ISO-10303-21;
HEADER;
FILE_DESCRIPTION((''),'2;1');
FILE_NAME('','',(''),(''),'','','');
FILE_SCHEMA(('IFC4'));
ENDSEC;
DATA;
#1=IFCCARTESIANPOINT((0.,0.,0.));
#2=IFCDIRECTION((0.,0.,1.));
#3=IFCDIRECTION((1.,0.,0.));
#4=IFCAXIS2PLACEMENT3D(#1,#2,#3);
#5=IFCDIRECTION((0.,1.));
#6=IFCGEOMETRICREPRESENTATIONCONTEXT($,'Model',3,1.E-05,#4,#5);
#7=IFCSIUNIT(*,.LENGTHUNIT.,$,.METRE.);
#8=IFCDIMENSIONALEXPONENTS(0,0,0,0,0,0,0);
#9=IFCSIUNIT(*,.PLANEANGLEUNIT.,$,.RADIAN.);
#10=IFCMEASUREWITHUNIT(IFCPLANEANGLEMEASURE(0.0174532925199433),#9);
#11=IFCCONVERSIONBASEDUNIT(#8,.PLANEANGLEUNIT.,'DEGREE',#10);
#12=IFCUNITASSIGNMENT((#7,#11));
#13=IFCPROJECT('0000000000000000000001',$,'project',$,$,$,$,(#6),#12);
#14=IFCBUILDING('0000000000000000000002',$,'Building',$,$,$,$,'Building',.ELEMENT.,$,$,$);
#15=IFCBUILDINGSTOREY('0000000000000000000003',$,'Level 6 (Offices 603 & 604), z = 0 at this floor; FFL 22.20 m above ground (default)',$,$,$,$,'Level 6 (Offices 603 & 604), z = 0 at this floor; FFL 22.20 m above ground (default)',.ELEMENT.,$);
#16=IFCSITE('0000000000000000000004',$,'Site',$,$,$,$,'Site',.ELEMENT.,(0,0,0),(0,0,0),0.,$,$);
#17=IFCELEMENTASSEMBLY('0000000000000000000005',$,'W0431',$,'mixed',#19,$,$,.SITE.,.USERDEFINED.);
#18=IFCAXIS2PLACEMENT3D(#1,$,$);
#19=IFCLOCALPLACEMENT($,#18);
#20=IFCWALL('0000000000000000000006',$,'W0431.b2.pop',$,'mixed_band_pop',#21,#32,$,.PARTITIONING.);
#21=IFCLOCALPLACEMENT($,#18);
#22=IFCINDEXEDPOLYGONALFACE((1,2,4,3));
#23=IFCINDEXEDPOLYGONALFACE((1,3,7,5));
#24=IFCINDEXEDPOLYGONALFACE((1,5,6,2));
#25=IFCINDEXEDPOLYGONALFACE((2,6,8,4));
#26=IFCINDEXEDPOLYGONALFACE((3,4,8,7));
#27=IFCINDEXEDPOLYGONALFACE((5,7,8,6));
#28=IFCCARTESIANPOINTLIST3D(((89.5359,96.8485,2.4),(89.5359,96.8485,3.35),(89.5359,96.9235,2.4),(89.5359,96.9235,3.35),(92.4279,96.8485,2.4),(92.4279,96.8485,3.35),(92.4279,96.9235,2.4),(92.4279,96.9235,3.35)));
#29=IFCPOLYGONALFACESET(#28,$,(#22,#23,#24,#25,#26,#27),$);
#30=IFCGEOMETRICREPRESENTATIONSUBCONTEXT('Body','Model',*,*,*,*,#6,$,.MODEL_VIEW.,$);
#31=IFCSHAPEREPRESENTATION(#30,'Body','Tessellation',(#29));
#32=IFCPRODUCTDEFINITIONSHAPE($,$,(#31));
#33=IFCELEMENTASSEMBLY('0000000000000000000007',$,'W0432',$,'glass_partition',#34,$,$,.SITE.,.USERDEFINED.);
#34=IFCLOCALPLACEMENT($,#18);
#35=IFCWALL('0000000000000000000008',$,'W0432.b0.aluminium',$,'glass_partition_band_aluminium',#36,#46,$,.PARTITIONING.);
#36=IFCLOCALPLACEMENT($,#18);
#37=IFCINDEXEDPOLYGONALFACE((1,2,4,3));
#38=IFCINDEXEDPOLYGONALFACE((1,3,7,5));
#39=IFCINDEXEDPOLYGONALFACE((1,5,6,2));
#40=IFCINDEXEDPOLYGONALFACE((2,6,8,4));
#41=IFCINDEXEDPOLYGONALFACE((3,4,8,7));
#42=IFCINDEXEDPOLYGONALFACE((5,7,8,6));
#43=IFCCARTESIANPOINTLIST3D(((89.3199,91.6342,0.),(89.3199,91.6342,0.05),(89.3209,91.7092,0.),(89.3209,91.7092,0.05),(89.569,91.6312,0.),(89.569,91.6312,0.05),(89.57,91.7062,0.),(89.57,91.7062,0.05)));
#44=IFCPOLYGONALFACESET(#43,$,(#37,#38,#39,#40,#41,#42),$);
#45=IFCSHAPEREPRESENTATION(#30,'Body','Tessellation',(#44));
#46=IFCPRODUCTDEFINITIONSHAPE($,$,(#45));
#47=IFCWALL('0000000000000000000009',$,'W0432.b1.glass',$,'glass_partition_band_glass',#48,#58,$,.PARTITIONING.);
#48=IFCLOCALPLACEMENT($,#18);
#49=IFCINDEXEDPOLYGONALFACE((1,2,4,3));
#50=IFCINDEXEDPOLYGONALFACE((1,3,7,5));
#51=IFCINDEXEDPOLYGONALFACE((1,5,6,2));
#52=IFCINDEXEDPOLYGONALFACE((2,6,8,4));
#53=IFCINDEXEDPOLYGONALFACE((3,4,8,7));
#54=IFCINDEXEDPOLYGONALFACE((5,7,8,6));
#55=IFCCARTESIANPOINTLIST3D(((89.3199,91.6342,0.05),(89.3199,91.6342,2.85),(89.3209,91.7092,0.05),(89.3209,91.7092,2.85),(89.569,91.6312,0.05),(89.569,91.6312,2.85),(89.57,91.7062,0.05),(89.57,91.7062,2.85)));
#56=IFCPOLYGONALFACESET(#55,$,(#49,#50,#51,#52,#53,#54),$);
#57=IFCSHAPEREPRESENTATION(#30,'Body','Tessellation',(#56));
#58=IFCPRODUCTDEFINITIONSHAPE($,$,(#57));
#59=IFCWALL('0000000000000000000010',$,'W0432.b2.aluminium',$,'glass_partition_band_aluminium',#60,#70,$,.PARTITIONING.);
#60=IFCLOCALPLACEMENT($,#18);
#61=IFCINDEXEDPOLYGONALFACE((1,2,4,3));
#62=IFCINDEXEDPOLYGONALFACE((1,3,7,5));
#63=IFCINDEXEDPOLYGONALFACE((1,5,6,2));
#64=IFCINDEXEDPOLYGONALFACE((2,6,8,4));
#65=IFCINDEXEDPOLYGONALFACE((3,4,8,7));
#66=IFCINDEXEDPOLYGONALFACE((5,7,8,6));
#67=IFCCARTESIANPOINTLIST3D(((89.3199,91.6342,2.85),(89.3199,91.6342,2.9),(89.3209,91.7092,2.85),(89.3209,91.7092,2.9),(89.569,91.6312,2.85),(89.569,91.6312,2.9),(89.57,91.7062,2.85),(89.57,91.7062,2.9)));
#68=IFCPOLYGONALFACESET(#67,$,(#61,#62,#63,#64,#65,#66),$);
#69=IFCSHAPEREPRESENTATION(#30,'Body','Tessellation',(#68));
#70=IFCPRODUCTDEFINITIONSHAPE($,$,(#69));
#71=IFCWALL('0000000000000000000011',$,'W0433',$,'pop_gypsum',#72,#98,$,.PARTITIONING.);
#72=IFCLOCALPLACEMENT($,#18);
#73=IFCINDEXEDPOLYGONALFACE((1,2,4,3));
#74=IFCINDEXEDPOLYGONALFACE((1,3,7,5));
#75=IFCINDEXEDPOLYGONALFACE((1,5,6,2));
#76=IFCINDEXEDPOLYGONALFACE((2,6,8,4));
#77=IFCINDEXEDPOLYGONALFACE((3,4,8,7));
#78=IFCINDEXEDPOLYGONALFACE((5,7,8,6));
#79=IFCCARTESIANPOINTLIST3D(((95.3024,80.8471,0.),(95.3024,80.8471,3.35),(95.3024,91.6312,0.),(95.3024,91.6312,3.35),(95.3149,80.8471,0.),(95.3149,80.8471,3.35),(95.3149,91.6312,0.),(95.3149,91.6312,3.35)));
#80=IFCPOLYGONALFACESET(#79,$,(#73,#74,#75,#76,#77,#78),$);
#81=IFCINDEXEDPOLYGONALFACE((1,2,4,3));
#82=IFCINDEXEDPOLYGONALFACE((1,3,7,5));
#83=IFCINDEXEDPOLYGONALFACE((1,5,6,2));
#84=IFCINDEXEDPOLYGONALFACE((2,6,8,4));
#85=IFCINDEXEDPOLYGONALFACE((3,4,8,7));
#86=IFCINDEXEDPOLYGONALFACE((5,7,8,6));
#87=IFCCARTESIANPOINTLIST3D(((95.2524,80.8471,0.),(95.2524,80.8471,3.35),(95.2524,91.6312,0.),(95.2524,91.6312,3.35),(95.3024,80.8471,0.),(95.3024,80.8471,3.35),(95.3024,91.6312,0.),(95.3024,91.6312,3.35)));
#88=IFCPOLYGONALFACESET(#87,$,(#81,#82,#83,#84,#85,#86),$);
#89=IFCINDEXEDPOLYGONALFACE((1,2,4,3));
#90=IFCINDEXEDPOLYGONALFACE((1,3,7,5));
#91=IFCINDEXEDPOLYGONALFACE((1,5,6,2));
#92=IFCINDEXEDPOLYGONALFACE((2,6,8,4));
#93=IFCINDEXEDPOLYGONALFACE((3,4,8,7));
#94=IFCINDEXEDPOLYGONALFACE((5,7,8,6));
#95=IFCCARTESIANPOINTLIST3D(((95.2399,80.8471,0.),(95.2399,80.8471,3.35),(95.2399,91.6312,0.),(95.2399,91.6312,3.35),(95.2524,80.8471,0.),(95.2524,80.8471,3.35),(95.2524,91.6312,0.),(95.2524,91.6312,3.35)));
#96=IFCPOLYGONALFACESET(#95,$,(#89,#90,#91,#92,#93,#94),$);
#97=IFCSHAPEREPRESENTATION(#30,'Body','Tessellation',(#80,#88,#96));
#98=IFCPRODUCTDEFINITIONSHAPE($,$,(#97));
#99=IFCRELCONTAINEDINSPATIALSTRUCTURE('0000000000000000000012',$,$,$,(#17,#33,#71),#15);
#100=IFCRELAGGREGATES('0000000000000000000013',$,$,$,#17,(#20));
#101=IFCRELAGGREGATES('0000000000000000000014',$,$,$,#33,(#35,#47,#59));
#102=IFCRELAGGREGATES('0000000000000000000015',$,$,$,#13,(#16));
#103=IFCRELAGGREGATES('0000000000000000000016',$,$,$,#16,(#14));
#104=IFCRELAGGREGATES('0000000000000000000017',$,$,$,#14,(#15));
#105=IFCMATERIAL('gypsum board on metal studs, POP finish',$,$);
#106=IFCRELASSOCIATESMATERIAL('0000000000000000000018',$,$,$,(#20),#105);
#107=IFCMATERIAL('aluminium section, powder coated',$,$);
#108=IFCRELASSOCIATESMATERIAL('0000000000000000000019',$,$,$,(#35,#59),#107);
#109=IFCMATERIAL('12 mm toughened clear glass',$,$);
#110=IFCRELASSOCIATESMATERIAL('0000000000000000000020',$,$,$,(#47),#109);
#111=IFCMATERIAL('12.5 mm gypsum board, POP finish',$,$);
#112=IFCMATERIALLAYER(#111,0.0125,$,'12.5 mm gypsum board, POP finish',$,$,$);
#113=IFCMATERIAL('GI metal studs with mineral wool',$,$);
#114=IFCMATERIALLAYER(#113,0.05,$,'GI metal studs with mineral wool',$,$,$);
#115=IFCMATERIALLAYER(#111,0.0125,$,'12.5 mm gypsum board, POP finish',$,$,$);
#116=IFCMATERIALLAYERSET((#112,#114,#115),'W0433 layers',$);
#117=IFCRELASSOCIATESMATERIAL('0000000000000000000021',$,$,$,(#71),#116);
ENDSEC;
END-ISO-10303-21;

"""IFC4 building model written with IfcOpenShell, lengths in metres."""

from ifc_helpers import new_model, entity, si_unit, converted_unit, direction, frame, frame_2d, origin_with_axes, place, context, subcontext, project, spatial, rectangle, extrude, material, layer, layer_set, layer_usage, element, aggregate, save


model = new_model("IFC4")

# Units and contexts
model_context = context("Model", 3, precision=1e-05, world=origin_with_axes(), true_north=direction((0.0, 1.0)))
body_context = subcontext(model_context, "Body", "Model", "MODEL_VIEW")
ifc_project = project(units=[si_unit("LENGTHUNIT", "METRE"), converted_unit("PLANEANGLEUNIT", "DEGREE", entity("IfcPlaneAngleMeasure", 0.0174532925199433), si_unit("PLANEANGLEUNIT", "RADIAN"), dimensions=[0, 0, 0, 0, 0, 0, 0])], contexts=[model_context])

# Site, building, storey
site = spatial("IfcSite", under=ifc_project, Name="Site", LongName="Site", CompositionType="ELEMENT", RefLatitude=(0, 0, 0), RefLongitude=(0, 0, 0), RefElevation=0.0)
building = spatial("IfcBuilding", under=site, Name="Building", LongName="Building", CompositionType="ELEMENT")
storey = spatial("IfcBuildingStorey", under=building, Name="Level 6 (Offices 603 & 604), z = 0 at this floor; FFL 22.20 m above ground (default)", LongName="Level 6 (Offices 603 & 604), z = 0 at this floor; FFL 22.20 m above ground (default)", CompositionType="ELEMENT")

# Element assemblies, walls
ifc_material_1 = material(Name="12 mm toughened clear glass")
placement = place(None, origin_with_axes())
ifc_material_2 = material(Name="aluminium section, powder coated")
ifc_material_3 = material(Name="gypsum board on metal studs, POP finish")
assembly_1 = element("IfcElementAssembly", 1, inside=storey, Name="W0431", ObjectType="mixed", AssemblyPlace="SITE", PredefinedType="USERDEFINED")
wall_1 = element("IfcWall", 2, at=placement, material=ifc_material_3, Name="W0431.b2.pop", ObjectType="mixed_band_pop", PredefinedType="PARTITIONING", context=body_context, shape_type="SweptSolid", body=[
    extrude(rectangle(XDim=2.892, YDim=0.075, at=frame_2d((0.0, 0.0), x_axis=(1.0, 0.0))), frame((90.9819, 96.886, 2.4), z_axis=(0.0, 0.0, 1.0), x_axis=(1.0, 0.0, 0.0)), (0.0, 0.0, 1.0), 0.95),
])
aggregate(assembly_1, [wall_1])
assembly_2 = element("IfcElementAssembly", 3, inside=storey, Name="W0432", ObjectType="glass_partition", AssemblyPlace="SITE", PredefinedType="USERDEFINED")
wall_2 = element("IfcWall", 4, at=placement, material=ifc_material_2, Name="W0432.b0.aluminium", ObjectType="glass_partition_band_aluminium", PredefinedType="PARTITIONING", context=body_context, shape_type="SweptSolid", body=[
    extrude(rectangle(XDim=0.2491, YDim=0.075, at=frame_2d((0.0, 0.0), x_axis=(0.999927, -0.012042))), frame((89.445, 91.6702, 0.0), z_axis=(0.0, 0.0, 1.0), x_axis=(1.0, 0.0, 0.0)), (0.0, 0.0, 1.0), 0.05),
])
wall_3 = element("IfcWall", 5, at=placement, material=ifc_material_1, Name="W0432.b1.glass", ObjectType="glass_partition_band_glass", PredefinedType="PARTITIONING", context=body_context, shape_type="SweptSolid", body=[
    extrude(rectangle(XDim=0.2491, YDim=0.075, at=frame_2d((0.0, 0.0), x_axis=(0.999927, -0.012042))), frame((89.445, 91.6702, 0.05), z_axis=(0.0, 0.0, 1.0), x_axis=(1.0, 0.0, 0.0)), (0.0, 0.0, 1.0), 2.8),
])
wall_4 = element("IfcWall", 6, at=placement, material=ifc_material_2, Name="W0432.b2.aluminium", ObjectType="glass_partition_band_aluminium", PredefinedType="PARTITIONING", context=body_context, shape_type="SweptSolid", body=[
    extrude(rectangle(XDim=0.2491, YDim=0.075, at=frame_2d((0.0, 0.0), x_axis=(0.999927, -0.012042))), frame((89.445, 91.6702, 2.85), z_axis=(0.0, 0.0, 1.0), x_axis=(1.0, 0.0, 0.0)), (0.0, 0.0, 1.0), 0.05),
])
aggregate(assembly_2, [wall_2, wall_3, wall_4])

# Wall
ifc_material_4 = material(Name="12.5 mm gypsum board, POP finish")
ifc_layer_1 = layer(ifc_material_4, 0.0125, Name="12.5 mm gypsum board, POP finish")
ifc_material_5 = material(Name="GI metal studs with mineral wool")
ifc_layer_2 = layer(ifc_material_5, 0.05, Name="GI metal studs with mineral wool")
ifc_layer_3 = layer(ifc_material_4, 0.0125, Name="12.5 mm gypsum board, POP finish")
ifc_layer_set = layer_set([ifc_layer_1, ifc_layer_2, ifc_layer_3], Name="W0433 layers")
ifc_layer_usage = layer_usage(ifc_layer_set, "AXIS2", "POSITIVE", -0.0375)
element("IfcWall", 7, at=placement, inside=storey, material=ifc_layer_usage, Name="W0433", ObjectType="pop_gypsum", PredefinedType="PARTITIONING", context=body_context, shape_type="SweptSolid", body=[
    extrude(rectangle(XDim=10.7841, YDim=0.0125, at=frame_2d((0.0, 0.0), x_axis=(0.0, 1.0))), frame((95.3087, 86.2391, 0.0), z_axis=(0.0, 0.0, 1.0), x_axis=(1.0, 0.0, 0.0)), (0.0, 0.0, 1.0), 3.35),
    extrude(rectangle(XDim=10.7841, YDim=0.05, at=frame_2d((-0.0312, 0.0), x_axis=(0.0, 1.0))), frame((95.3087, 86.2391, 0.0), z_axis=(0.0, 0.0, 1.0), x_axis=(1.0, 0.0, 0.0)), (0.0, 0.0, 1.0), 3.35),
    extrude(rectangle(XDim=10.7841, YDim=0.0125, at=frame_2d((-0.0625, 0.0), x_axis=(0.0, 1.0))), frame((95.3087, 86.2391, 0.0), z_axis=(0.0, 0.0, 1.0), x_axis=(1.0, 0.0, 0.0)), (0.0, 0.0, 1.0), 3.35),
])

save(model, "model.ifc")
